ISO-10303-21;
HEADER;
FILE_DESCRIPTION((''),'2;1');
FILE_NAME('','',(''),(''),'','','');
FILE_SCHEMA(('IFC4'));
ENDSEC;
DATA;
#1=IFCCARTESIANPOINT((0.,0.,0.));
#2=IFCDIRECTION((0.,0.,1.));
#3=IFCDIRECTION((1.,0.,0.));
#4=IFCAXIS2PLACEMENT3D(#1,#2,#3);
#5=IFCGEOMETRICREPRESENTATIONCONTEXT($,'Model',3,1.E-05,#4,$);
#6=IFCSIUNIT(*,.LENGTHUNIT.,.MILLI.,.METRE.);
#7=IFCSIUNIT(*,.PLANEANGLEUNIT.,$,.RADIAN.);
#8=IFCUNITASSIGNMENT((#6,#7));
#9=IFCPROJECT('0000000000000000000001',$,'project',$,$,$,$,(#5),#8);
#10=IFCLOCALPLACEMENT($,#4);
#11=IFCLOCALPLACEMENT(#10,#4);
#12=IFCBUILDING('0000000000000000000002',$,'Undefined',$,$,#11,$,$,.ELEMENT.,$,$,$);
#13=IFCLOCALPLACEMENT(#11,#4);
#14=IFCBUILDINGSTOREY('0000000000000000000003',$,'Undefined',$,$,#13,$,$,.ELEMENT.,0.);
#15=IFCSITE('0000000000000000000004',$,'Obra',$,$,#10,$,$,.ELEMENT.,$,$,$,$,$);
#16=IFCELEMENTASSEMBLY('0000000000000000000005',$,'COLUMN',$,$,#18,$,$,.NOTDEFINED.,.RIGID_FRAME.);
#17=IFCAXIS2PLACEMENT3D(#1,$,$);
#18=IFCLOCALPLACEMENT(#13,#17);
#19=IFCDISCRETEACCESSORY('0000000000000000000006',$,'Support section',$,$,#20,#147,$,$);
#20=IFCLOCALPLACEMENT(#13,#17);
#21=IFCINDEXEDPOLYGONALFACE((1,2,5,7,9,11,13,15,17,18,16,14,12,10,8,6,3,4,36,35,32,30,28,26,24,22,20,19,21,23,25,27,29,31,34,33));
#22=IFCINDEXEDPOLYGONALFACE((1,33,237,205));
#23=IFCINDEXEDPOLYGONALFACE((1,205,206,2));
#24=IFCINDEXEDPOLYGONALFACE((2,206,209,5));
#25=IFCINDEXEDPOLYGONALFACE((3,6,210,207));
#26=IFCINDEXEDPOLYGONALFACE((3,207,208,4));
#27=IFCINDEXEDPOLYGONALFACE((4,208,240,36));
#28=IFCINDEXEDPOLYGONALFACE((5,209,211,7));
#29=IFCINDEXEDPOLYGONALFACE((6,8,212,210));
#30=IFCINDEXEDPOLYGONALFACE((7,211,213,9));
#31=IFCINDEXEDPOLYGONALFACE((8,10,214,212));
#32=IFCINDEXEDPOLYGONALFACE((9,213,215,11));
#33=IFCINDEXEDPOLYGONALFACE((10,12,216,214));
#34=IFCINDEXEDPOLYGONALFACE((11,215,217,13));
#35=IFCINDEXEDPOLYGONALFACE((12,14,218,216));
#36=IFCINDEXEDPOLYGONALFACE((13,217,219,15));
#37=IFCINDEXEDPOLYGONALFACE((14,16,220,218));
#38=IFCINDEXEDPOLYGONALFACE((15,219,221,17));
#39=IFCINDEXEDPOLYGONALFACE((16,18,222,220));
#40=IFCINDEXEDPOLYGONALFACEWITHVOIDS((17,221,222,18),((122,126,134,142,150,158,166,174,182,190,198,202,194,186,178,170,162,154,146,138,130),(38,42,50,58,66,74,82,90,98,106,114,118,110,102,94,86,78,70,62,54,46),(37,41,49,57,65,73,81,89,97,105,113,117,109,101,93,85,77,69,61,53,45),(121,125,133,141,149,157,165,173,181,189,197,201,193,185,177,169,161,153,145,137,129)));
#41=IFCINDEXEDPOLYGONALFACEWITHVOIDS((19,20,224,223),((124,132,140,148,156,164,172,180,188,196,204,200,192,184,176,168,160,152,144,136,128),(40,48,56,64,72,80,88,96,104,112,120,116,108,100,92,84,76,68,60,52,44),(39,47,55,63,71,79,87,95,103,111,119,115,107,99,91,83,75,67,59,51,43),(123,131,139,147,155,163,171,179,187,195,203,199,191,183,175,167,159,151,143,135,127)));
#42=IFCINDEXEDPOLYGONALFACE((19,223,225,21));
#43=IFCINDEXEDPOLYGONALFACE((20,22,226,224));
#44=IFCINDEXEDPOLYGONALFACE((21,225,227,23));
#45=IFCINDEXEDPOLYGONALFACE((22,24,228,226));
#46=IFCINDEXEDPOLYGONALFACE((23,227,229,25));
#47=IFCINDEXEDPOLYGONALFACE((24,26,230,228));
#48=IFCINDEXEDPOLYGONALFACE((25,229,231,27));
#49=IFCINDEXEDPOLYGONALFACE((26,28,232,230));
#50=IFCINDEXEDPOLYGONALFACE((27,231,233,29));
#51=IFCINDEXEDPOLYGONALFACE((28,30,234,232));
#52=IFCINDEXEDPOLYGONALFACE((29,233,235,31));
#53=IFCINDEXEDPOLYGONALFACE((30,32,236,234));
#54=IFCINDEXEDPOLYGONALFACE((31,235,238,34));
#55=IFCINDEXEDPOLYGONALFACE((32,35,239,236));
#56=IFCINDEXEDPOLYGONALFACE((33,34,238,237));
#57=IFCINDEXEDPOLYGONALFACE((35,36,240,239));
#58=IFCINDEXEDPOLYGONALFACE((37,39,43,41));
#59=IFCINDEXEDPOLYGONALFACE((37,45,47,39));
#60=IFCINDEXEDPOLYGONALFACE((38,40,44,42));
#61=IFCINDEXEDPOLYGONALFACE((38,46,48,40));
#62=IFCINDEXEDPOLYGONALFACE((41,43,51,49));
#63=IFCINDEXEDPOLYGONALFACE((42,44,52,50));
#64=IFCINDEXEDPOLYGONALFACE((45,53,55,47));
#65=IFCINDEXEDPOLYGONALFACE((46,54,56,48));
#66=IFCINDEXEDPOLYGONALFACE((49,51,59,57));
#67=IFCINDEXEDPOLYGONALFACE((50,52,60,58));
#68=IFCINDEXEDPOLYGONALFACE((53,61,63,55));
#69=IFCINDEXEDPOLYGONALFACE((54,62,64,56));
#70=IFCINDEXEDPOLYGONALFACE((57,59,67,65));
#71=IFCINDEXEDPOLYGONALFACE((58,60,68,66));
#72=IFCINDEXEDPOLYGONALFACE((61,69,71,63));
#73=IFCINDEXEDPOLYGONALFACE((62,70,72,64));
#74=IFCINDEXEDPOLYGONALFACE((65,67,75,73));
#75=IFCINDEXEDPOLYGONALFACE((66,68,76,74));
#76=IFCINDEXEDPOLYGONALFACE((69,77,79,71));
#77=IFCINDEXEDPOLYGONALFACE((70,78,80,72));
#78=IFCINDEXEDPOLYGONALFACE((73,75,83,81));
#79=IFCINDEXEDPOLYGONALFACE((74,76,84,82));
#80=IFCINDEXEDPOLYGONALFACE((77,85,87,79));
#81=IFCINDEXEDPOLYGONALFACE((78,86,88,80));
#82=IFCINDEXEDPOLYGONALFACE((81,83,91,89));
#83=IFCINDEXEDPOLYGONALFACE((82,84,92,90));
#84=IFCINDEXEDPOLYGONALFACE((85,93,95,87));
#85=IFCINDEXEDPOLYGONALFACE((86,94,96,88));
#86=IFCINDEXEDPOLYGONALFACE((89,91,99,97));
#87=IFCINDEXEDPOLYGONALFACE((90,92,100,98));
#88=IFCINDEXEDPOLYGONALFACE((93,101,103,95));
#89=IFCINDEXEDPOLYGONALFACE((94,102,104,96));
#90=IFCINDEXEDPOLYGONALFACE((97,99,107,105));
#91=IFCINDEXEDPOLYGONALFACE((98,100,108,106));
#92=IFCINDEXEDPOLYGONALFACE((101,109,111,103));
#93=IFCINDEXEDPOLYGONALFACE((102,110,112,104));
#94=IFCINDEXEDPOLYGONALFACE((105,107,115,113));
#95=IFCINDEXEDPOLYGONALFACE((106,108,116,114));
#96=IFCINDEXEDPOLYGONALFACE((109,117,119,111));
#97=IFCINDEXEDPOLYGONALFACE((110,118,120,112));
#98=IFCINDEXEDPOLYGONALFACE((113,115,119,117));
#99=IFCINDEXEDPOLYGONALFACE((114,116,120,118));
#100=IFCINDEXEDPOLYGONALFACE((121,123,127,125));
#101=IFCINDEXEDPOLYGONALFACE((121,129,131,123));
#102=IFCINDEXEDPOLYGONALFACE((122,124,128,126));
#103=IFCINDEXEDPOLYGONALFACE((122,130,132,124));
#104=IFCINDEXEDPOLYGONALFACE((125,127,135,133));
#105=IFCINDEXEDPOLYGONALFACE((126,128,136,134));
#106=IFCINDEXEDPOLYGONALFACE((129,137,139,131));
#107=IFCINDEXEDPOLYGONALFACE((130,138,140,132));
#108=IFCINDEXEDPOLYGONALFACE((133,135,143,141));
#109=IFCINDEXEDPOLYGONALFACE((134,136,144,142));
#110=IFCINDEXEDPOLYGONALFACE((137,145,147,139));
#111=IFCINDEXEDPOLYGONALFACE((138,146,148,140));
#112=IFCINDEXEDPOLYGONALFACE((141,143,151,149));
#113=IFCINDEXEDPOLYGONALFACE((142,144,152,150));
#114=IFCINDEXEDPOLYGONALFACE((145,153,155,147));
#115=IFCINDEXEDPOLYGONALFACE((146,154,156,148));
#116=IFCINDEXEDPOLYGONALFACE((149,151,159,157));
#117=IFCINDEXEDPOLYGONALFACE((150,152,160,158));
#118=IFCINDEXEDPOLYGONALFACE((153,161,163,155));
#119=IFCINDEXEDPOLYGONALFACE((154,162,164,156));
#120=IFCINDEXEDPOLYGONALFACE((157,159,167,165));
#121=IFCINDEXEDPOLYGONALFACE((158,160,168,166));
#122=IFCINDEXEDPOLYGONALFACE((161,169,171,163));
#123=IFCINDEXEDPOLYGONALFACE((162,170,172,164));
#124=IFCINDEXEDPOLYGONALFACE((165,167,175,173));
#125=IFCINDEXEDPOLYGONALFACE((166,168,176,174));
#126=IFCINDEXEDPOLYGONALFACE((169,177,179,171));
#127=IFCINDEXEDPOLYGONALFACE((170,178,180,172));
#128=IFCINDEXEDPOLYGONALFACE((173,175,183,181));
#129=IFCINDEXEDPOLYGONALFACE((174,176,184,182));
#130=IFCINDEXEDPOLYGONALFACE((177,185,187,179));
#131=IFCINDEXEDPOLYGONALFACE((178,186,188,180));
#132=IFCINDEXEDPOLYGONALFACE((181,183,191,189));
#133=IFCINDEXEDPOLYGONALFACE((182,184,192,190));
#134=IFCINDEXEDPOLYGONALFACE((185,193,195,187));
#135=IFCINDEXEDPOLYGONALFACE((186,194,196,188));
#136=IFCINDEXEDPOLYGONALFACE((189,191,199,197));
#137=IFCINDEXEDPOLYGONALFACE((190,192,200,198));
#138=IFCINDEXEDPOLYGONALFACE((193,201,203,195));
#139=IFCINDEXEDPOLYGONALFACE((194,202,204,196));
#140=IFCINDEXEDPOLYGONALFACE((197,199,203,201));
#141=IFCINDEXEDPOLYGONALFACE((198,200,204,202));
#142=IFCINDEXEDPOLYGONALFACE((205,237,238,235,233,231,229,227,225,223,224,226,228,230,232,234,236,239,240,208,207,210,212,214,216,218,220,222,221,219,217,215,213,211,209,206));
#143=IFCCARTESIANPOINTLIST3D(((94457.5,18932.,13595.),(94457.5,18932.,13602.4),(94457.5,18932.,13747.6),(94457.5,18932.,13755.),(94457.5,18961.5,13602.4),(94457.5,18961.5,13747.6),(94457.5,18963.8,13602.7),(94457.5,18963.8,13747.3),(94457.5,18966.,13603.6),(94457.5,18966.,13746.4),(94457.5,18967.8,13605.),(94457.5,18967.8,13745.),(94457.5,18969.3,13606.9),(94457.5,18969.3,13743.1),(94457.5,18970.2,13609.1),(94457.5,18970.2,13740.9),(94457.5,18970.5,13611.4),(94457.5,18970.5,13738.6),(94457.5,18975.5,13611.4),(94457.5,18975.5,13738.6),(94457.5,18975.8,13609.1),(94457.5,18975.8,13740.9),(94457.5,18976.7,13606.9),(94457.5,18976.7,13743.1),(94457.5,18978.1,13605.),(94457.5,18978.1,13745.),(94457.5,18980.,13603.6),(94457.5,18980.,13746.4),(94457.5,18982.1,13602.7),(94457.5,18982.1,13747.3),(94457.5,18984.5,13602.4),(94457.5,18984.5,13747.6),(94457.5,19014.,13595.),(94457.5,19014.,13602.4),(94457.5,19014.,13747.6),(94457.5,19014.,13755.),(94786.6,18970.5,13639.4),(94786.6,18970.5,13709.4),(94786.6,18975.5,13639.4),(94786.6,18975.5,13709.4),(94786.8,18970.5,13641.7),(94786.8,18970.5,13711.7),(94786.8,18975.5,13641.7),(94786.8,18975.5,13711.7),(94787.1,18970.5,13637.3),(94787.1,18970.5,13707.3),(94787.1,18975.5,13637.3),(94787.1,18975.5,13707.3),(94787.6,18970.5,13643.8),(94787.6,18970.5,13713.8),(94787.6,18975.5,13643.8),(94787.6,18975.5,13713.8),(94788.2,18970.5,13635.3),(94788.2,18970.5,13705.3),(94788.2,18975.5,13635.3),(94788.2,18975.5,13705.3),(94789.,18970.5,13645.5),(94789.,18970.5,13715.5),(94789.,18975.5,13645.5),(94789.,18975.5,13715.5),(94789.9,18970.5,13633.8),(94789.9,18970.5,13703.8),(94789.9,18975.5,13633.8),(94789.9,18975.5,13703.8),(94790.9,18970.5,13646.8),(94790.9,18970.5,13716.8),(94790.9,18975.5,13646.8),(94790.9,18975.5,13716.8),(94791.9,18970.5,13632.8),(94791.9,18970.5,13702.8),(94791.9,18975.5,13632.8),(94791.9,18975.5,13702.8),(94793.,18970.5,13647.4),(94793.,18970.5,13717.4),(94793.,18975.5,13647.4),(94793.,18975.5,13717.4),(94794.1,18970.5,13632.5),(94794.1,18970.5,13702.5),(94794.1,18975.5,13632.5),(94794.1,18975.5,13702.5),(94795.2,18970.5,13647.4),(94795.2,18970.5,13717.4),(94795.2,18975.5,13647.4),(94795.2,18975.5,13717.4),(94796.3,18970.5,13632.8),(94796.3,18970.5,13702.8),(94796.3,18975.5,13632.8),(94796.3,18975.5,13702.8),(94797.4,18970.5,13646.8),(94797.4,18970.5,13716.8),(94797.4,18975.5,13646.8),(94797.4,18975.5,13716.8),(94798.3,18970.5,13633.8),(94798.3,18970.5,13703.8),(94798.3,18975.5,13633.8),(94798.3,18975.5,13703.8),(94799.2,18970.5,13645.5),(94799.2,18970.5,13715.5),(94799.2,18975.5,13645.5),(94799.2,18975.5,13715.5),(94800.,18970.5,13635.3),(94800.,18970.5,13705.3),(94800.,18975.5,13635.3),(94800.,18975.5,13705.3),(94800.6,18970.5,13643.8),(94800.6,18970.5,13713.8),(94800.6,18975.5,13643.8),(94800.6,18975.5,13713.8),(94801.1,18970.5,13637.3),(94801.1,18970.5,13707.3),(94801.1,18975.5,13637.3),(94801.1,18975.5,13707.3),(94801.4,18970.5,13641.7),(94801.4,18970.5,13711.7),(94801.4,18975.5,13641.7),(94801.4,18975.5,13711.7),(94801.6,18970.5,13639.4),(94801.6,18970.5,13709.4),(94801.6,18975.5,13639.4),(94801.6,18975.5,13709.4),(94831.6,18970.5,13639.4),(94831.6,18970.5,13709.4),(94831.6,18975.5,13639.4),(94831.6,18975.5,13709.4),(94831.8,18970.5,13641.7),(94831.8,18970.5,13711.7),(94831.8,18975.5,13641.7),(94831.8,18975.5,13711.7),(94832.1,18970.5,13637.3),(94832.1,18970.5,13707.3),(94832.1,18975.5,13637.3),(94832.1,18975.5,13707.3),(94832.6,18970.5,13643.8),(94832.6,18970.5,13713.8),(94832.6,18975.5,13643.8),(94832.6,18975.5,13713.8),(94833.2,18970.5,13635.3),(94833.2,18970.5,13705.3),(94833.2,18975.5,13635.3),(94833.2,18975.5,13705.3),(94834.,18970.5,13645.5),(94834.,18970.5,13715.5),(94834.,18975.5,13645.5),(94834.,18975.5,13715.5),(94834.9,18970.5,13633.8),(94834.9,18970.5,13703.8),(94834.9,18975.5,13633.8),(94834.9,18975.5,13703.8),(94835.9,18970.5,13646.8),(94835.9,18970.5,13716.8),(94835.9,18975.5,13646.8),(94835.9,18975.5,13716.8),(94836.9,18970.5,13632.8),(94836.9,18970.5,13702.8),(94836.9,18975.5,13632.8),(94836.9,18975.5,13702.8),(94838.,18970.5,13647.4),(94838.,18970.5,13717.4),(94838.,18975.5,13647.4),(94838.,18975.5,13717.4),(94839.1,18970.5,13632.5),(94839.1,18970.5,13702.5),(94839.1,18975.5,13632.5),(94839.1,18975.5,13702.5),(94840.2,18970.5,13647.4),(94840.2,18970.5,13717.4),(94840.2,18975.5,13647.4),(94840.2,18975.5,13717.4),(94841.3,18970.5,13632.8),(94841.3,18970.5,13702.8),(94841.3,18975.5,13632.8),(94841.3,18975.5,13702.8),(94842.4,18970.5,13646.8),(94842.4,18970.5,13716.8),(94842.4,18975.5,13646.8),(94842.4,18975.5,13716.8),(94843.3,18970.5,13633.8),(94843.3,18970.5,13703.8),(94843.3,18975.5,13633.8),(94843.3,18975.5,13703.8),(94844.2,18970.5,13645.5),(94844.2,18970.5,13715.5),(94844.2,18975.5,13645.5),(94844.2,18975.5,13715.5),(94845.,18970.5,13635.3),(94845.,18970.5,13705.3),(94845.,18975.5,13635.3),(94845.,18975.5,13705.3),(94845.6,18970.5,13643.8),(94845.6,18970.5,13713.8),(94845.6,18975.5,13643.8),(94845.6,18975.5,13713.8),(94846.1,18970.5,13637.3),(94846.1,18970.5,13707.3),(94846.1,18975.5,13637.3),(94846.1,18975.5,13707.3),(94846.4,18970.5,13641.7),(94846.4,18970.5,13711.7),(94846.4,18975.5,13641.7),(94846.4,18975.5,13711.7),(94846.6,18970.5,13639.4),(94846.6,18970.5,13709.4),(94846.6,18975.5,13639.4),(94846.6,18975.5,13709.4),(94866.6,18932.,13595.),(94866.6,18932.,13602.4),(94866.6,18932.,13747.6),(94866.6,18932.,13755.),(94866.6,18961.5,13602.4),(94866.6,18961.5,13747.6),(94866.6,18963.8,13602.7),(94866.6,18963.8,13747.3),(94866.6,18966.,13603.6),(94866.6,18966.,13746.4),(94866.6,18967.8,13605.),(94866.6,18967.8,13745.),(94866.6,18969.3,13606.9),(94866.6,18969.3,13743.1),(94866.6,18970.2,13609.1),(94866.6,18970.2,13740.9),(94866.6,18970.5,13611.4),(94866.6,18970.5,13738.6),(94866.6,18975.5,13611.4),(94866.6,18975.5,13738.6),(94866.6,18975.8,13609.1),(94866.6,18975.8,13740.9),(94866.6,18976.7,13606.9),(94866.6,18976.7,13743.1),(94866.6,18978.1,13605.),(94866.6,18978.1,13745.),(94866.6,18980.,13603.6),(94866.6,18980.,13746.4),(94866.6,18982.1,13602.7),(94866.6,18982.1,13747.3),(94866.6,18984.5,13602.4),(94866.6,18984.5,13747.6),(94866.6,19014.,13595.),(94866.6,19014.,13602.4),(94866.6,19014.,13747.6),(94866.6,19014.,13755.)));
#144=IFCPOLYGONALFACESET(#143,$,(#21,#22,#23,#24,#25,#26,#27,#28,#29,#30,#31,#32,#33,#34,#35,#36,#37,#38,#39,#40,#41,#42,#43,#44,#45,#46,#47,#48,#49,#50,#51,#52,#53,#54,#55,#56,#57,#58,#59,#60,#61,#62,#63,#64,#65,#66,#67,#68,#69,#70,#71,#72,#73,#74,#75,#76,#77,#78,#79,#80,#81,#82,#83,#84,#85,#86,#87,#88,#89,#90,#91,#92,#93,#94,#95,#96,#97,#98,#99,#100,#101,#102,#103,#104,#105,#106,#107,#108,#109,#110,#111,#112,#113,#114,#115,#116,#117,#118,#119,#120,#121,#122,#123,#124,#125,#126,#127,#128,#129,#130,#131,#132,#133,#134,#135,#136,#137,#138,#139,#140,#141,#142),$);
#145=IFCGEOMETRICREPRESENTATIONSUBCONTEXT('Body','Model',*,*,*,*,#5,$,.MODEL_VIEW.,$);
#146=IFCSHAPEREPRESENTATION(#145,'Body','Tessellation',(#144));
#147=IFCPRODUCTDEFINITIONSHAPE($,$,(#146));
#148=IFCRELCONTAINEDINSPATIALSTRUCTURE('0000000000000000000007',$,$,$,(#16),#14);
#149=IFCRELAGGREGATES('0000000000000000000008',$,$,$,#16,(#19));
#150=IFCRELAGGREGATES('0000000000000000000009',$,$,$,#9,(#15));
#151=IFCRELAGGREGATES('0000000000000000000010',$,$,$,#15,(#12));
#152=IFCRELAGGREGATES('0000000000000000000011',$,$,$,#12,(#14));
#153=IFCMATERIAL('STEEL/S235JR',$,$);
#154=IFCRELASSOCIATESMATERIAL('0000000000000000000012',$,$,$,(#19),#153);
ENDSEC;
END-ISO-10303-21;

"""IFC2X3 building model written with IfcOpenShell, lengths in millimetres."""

from ifc_helpers import new_model, si_unit, frame, origin_with_axes, origin_2d_with_axis, place, context, subcontext, project, spatial, circle, i_section, extrude, clip, halfspace, source, transform, mapped, material, element, aggregate, save


model = new_model("IFC2X3")

# Units and contexts
model_context = context("Model", 3, precision=1e-05, world=origin_with_axes())
body_context = subcontext(model_context, "Body", "Model", "MODEL_VIEW")
ifc_project = project(units=[si_unit("LENGTHUNIT", "METRE", prefix="MILLI"), si_unit("PLANEANGLEUNIT", "RADIAN")], contexts=[model_context])

# Site, building, storey
site_placement = place(None, origin_with_axes())
site = spatial("IfcSite", under=ifc_project, at=site_placement, Name="Obra", CompositionType="ELEMENT")
building_placement = place(site_placement, origin_with_axes())
building = spatial("IfcBuilding", under=site, at=building_placement, Name="Undefined", CompositionType="ELEMENT")
storey_placement = place(building_placement, origin_with_axes())
storey = spatial("IfcBuildingStorey", under=building, at=storey_placement, Name="Undefined", CompositionType="ELEMENT", Elevation=0.0)

# Shared definitions
ifc_material_1 = material(Name="STEEL/S235JR")

# Element assembly, discrete accessory, opening
assembly_1_placement = place(storey_placement, origin_with_axes())
assembly_1 = element("IfcElementAssembly", 1, at=assembly_1_placement, inside=storey, Name="COLUMN", AssemblyPlace="NOTDEFINED", PredefinedType="RIGID_FRAME")
discrete_accessory_1_placement = place(assembly_1_placement, frame((94458.3, 18973.0, 13675.0), z_axis=(0.0, 0.0, 1.0), x_axis=(1.0, 0.0, 0.0)))
discrete_accessory_1 = element("IfcDiscreteAccessory", 2, at=discrete_accessory_1_placement, material=ifc_material_1, Name="Support section", context=body_context, shape_type="Clipping", body=[
    clip(clip(extrude(i_section(OverallWidth=82.0, OverallDepth=160.0, WebThickness=5.0, FlangeThickness=7.4, FilletRadius=9.0, at=origin_2d_with_axis()), frame((408.3, 0.0, 0.0), z_axis=(-1.0, 0.0, 0.0), x_axis=(0.0, -1.0, 0.0)), (0.0, 0.0, 1.0), 409.1), halfspace(frame((408.3, 0.0, -180.0), z_axis=(-1.0, 0.0, 0.0), x_axis=(0.0, 1.0, 0.0)), True)), halfspace(frame((-0.8, 0.0, 580.0), z_axis=(-1.0, -0.000033, 0.0), x_axis=(0.000033, -1.0, 0.0)), False)),
])
shared_shape_1 = source(origin_with_axes(), body_context, "Body", "SweptSolid", [
    extrude(circle(Radius=7.5, at=origin_2d_with_axis()), frame((0.0, -2.6, 0.0), z_axis=(0.0, 1.0, 0.0), x_axis=(1.0, 0.0, 0.0)), (0.0, 0.0, 1.0), 5.2),
])
opening_1_placement = place(assembly_1_placement, frame((94816.6, 18973.0, 13710.0), z_axis=(-1.0, 0.0, 0.0), x_axis=(0.0, 0.0, -1.0)))
element("IfcOpeningElement", 3, at=opening_1_placement, cuts=discrete_accessory_1, ObjectType="Opening", context=body_context, shape_type="MappedRepresentation", body=[
    mapped(shared_shape_1, transform((0.0, 0.0, -22.5))),
    mapped(shared_shape_1, transform((70.0, 0.0, -22.5))),
    mapped(shared_shape_1, transform((0.0, 0.0, 22.5))),
    mapped(shared_shape_1, transform((70.0, 0.0, 22.5))),
])
aggregate(assembly_1, [discrete_accessory_1])

save(model, "model.ifc")
